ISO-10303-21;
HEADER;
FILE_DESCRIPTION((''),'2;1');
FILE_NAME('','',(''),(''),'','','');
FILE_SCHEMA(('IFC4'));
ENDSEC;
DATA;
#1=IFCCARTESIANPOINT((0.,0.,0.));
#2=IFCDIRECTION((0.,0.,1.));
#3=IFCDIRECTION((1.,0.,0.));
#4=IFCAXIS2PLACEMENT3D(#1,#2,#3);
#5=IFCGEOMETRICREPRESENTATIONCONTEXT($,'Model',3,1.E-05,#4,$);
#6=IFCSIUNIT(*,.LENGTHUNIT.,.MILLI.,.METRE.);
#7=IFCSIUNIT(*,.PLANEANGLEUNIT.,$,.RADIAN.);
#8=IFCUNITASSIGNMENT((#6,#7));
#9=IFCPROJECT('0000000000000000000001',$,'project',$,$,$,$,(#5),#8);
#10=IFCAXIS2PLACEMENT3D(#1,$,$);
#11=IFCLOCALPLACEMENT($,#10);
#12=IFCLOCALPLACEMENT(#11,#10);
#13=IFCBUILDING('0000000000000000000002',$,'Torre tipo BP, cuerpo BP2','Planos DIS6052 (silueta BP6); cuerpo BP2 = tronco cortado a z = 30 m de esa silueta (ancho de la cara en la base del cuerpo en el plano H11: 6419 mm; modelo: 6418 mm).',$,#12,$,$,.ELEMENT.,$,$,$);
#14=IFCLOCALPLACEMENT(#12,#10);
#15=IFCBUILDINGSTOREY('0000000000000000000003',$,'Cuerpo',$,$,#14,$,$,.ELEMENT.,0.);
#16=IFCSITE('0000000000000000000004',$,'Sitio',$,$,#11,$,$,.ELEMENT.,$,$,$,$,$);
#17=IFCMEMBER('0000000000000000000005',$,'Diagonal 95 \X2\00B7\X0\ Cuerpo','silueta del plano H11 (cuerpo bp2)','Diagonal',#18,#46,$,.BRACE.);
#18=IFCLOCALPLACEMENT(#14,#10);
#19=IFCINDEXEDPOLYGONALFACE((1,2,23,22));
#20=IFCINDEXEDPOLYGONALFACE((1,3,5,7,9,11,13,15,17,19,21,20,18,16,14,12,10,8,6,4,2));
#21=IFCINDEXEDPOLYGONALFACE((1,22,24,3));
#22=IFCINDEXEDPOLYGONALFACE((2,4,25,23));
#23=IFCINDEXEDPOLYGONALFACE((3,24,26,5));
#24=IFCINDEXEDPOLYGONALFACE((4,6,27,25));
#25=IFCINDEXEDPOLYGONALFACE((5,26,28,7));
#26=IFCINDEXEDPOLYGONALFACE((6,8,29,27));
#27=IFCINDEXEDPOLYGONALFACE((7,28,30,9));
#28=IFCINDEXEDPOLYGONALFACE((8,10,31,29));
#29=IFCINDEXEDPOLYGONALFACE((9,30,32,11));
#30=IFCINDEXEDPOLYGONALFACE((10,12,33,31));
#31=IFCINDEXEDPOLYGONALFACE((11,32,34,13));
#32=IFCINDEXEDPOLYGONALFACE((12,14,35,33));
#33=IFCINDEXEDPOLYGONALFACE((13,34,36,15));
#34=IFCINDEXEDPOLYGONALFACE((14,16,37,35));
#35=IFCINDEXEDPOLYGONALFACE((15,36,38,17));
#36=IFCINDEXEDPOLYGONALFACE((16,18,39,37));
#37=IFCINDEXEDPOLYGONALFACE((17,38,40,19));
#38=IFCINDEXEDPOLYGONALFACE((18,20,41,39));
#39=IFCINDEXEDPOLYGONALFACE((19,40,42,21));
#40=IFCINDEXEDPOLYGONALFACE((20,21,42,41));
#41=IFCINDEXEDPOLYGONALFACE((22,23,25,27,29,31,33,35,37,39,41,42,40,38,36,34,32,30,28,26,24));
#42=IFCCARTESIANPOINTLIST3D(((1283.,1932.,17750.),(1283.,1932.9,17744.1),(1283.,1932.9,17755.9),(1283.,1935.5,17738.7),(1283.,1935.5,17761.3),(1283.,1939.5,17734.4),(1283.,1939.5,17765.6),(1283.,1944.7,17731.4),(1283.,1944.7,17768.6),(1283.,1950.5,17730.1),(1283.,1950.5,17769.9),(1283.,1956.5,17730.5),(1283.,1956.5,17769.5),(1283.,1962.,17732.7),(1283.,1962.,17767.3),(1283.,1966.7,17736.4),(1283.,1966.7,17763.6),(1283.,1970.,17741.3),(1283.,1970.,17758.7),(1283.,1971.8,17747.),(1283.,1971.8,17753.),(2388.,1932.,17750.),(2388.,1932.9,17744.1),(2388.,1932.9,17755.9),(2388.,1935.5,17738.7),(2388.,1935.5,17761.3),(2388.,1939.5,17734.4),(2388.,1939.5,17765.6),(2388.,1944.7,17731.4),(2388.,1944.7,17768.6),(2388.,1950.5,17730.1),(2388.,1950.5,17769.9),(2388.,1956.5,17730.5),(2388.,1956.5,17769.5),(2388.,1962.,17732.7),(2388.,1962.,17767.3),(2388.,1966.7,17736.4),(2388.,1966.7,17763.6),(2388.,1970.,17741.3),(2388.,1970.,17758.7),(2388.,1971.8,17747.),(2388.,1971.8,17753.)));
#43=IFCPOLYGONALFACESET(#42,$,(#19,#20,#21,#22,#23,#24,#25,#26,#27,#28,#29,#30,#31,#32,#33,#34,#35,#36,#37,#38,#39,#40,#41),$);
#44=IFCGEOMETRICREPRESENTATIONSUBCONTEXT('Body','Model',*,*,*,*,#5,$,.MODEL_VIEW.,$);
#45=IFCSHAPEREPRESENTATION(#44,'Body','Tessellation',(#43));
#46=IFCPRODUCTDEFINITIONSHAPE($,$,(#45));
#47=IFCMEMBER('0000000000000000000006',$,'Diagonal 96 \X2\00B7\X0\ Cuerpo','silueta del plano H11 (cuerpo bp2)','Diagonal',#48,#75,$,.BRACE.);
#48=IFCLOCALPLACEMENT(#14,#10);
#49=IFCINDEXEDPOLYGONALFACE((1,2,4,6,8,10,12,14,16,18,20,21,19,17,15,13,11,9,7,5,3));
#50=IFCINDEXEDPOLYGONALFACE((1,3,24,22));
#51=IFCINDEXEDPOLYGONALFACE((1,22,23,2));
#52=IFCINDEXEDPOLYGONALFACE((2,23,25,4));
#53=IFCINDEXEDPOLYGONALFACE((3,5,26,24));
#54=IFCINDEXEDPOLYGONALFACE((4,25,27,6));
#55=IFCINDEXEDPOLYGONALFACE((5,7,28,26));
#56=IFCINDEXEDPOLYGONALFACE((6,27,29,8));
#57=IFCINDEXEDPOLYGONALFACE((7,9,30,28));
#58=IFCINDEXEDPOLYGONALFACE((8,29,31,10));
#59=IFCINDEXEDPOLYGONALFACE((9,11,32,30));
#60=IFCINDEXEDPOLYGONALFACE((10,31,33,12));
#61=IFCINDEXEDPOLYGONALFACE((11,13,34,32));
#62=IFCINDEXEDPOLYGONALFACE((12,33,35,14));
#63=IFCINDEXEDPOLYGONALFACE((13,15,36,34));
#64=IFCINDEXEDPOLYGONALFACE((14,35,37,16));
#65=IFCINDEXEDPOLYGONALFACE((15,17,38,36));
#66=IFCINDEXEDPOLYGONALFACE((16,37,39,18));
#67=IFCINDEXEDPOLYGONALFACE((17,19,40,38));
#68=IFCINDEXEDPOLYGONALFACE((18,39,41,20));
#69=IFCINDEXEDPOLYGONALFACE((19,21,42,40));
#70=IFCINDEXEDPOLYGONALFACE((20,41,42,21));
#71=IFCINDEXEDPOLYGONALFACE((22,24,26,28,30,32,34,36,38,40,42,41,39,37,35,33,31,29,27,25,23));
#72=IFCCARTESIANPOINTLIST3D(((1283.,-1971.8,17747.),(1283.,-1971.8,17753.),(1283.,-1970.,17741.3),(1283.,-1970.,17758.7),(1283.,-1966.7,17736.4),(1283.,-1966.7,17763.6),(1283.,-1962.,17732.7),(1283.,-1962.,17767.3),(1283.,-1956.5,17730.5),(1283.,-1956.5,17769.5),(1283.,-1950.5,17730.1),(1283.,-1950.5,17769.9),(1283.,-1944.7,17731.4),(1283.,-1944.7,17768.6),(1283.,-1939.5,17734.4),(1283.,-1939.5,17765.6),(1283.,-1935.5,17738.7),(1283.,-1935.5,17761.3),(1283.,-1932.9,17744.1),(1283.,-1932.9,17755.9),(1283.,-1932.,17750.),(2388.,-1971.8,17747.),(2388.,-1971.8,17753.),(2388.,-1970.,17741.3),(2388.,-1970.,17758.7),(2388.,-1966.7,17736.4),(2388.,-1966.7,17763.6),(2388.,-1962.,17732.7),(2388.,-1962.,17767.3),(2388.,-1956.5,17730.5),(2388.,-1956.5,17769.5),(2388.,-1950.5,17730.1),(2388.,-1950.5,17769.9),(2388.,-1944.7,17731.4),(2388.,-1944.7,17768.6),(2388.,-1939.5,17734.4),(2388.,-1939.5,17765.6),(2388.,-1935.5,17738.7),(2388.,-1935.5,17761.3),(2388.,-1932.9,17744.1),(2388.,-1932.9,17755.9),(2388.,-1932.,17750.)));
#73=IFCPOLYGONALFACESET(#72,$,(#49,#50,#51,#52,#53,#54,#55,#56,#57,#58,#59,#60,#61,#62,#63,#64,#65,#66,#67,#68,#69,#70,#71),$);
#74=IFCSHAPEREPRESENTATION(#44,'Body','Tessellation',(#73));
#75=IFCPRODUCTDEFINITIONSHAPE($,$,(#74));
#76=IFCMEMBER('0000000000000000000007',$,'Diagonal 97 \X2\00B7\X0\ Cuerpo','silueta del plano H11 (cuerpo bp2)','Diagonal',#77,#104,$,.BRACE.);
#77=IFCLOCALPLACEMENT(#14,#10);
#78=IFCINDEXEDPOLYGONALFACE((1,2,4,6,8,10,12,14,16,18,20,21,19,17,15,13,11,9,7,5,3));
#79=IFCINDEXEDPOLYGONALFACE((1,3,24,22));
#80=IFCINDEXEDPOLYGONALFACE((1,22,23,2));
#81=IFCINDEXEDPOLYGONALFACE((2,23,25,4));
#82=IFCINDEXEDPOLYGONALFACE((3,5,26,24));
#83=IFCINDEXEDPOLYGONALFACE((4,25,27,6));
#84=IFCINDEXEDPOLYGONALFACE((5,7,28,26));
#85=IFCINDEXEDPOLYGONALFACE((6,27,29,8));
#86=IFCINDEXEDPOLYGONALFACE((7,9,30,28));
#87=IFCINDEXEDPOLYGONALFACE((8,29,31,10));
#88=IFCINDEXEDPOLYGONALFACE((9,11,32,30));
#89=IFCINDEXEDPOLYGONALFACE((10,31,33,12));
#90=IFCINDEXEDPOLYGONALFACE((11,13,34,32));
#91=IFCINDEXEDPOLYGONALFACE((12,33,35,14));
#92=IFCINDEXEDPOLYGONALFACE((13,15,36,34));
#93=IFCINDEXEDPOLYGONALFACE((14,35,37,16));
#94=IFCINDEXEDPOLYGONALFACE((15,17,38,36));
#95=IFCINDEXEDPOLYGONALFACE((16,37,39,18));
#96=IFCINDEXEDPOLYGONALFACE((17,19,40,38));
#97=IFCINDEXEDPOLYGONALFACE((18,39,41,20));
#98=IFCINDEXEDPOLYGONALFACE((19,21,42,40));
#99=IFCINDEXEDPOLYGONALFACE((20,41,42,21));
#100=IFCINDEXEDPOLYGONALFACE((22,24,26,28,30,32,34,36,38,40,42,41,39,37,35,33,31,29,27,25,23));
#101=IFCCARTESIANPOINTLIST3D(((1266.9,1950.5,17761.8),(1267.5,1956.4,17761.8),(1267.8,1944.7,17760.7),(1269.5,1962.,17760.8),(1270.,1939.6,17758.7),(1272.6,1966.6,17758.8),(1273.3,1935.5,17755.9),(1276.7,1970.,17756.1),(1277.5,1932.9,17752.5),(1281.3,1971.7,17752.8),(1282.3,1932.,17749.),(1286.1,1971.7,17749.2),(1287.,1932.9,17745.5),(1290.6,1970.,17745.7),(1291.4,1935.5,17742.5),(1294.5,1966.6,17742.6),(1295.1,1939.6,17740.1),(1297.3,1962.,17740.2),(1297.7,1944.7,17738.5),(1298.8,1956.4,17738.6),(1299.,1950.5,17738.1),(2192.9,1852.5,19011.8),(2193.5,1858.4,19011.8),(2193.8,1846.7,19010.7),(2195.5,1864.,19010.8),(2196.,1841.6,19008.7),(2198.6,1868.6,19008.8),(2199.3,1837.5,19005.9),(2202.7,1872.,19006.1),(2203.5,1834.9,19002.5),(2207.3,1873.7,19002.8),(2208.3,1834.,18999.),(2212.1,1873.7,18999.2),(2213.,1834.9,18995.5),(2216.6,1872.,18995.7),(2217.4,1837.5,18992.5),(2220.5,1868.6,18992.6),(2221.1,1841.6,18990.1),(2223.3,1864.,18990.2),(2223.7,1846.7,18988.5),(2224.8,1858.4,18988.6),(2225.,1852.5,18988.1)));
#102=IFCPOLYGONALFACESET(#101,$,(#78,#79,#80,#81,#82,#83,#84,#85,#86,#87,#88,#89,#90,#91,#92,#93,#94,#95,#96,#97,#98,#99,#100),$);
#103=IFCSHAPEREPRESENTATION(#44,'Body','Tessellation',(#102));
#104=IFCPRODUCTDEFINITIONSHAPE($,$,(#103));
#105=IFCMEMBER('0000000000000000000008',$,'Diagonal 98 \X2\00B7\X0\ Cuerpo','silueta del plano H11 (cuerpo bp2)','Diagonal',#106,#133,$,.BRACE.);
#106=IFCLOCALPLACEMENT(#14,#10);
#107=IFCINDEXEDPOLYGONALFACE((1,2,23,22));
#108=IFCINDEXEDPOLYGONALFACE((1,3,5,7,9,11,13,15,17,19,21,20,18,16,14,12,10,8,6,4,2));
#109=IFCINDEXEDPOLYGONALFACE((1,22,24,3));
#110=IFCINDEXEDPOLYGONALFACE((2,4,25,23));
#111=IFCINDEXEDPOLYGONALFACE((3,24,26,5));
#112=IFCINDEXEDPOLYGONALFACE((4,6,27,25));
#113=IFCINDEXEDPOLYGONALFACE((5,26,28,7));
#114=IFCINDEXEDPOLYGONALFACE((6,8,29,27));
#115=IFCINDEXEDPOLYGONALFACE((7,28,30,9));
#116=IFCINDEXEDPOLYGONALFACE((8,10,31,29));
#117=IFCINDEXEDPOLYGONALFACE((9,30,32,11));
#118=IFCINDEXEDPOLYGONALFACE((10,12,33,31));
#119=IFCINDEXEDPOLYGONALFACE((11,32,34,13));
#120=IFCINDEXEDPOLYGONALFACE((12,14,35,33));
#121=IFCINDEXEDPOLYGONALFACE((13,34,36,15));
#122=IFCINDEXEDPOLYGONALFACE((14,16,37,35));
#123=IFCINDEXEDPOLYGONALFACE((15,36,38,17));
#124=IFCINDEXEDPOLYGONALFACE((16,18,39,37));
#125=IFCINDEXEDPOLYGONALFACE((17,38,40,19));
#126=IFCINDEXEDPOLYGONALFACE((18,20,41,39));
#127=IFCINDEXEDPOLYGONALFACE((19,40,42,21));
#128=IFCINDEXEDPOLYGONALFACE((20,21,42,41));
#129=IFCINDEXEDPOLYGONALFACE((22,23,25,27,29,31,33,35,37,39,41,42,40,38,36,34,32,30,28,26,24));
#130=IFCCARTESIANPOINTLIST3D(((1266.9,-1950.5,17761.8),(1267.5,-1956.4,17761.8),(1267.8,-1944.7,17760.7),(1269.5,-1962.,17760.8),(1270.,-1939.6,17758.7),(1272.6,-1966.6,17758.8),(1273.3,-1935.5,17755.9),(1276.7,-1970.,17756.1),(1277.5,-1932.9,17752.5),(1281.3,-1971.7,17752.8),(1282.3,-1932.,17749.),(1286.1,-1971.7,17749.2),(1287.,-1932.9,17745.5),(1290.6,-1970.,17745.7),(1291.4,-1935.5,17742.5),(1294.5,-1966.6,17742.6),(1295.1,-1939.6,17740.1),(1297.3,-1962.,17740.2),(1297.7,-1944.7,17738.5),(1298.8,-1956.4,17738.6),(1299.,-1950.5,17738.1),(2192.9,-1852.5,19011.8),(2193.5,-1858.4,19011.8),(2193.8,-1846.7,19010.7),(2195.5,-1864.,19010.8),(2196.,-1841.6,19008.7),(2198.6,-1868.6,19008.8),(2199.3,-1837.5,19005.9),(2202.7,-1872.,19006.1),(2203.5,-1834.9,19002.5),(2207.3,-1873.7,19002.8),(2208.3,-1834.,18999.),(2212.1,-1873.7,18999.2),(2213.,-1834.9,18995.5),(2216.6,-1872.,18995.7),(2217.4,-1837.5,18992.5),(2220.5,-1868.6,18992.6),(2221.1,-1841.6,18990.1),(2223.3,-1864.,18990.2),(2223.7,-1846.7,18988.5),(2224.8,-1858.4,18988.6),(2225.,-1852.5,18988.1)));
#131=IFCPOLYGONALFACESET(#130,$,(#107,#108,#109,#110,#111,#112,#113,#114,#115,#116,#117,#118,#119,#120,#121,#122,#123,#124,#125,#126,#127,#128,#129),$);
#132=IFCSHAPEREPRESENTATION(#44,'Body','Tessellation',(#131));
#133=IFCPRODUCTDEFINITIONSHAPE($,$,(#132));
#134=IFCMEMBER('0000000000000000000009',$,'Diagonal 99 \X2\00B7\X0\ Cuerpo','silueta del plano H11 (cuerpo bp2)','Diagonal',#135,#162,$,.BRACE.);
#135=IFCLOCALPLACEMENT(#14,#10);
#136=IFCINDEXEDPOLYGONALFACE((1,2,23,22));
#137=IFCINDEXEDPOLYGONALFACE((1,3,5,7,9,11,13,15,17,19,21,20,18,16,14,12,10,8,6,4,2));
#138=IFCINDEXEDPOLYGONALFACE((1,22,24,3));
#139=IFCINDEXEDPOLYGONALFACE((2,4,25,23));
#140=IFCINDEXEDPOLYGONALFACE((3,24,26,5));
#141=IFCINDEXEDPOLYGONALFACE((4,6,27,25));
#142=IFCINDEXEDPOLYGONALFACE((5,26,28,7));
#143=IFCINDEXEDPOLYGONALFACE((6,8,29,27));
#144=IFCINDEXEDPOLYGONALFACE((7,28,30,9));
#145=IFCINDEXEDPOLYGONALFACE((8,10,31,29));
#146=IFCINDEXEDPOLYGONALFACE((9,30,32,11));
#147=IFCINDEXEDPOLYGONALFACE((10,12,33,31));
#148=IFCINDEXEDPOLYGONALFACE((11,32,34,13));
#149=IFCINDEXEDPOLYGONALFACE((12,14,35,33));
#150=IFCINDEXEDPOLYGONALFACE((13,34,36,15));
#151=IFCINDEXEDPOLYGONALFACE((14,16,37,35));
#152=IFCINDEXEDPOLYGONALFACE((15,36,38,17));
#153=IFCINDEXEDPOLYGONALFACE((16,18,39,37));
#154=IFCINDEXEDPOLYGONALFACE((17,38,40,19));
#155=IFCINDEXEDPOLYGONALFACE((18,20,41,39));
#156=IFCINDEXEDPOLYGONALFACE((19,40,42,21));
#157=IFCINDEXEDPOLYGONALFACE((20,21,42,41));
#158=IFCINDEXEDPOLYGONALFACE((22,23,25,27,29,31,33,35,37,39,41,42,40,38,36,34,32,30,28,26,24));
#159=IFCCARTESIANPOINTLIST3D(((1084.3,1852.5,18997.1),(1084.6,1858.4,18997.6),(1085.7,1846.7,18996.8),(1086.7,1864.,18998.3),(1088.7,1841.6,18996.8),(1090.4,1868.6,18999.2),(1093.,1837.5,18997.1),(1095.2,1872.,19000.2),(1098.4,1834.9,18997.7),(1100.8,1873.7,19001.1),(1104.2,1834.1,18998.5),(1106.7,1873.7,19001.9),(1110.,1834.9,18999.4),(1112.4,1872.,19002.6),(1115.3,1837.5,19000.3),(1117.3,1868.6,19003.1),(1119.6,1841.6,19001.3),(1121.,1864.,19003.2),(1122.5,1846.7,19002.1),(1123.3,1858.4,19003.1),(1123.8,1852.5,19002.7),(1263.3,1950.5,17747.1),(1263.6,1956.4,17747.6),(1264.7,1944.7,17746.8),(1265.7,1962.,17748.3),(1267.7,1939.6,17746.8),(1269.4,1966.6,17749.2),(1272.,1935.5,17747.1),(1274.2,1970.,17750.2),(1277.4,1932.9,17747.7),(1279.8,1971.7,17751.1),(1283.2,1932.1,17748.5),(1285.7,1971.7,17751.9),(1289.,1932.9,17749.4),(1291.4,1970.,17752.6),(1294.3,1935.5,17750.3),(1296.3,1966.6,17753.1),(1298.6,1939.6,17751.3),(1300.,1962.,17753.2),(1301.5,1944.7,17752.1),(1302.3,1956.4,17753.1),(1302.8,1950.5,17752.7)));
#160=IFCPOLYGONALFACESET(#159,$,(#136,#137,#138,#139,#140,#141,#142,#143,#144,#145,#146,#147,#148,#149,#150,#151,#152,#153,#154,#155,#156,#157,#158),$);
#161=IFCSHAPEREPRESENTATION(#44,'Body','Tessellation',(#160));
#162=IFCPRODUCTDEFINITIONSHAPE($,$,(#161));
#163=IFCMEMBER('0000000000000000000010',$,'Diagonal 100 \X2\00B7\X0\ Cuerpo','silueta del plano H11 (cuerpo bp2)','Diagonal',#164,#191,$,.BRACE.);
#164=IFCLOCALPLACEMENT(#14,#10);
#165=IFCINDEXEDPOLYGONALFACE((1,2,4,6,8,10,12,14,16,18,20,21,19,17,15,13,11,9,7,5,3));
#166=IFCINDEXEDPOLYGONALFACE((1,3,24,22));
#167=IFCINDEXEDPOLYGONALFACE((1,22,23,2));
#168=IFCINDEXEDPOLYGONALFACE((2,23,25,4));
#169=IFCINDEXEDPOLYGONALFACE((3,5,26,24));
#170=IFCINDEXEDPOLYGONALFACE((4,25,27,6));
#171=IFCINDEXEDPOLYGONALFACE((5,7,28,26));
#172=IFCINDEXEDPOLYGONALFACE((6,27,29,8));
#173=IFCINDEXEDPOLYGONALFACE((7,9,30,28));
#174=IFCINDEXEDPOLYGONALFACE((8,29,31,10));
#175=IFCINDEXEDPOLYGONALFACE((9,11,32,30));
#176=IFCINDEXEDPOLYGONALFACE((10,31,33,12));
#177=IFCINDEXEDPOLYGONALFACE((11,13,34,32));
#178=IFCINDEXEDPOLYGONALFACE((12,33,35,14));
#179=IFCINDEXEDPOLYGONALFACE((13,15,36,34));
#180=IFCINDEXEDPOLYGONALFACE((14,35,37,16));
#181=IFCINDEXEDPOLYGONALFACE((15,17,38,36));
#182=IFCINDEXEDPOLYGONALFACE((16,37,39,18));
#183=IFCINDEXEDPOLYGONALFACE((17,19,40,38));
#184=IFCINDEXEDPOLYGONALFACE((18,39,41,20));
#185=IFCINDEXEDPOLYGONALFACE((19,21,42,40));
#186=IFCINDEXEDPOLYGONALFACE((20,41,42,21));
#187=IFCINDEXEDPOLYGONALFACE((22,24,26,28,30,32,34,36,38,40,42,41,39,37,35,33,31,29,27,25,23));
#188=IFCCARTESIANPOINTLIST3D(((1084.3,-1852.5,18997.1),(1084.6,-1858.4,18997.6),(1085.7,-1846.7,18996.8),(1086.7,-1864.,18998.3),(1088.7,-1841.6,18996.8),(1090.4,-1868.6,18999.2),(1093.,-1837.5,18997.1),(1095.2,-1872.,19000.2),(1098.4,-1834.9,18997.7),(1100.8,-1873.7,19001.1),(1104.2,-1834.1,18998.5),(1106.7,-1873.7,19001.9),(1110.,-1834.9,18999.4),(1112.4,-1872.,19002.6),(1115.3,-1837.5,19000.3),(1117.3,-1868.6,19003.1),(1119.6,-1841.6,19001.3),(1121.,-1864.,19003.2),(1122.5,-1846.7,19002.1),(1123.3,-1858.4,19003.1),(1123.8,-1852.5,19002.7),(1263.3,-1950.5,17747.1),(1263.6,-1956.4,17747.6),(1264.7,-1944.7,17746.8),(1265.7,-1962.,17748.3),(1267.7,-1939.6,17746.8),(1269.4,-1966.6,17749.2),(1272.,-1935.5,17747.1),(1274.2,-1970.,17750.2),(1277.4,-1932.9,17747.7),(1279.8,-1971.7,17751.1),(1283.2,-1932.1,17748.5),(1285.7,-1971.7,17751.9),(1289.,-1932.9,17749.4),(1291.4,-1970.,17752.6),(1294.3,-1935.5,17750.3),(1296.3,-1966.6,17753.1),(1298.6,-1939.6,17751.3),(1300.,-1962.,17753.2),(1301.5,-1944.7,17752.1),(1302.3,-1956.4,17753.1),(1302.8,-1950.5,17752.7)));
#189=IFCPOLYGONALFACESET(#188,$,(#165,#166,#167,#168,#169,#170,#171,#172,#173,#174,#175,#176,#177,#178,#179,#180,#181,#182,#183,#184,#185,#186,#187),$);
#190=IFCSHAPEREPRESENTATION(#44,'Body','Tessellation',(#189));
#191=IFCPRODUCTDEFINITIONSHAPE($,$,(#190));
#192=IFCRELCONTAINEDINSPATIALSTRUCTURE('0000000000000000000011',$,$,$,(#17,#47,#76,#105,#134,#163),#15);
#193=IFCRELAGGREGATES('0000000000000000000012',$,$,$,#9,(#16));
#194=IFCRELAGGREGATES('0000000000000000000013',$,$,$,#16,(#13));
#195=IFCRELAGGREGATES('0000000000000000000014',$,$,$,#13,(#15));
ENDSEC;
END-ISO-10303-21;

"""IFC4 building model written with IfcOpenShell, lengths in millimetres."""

from ifc_helpers import new_model, si_unit, frame, origin, origin_with_axes, place, context, subcontext, project, spatial, circle, extrude, element, save


model = new_model("IFC4")

# Units and contexts
model_context = context("Model", 3, precision=1e-05, world=origin_with_axes())
body_context = subcontext(model_context, "Body", "Model", "MODEL_VIEW")
ifc_project = project(units=[si_unit("LENGTHUNIT", "METRE", prefix="MILLI"), si_unit("PLANEANGLEUNIT", "RADIAN")], contexts=[model_context])

# Site, building, storey
site_placement = place(None, origin())
site = spatial("IfcSite", under=ifc_project, at=site_placement, Name="Sitio", CompositionType="ELEMENT")
building_placement = place(site_placement, origin())
building = spatial("IfcBuilding", under=site, at=building_placement, Name="Torre tipo BP, cuerpo BP2", Description="Planos DIS6052 (silueta BP6); cuerpo BP2 = tronco cortado a z = 30 m de esa silueta (ancho de la cara en la base del cuerpo en el plano H11: 6419 mm; modelo: 6418 mm).", CompositionType="ELEMENT")
storey_placement = place(building_placement, origin())
storey = spatial("IfcBuildingStorey", under=building, at=storey_placement, Name="Cuerpo", CompositionType="ELEMENT", Elevation=0.0)

# Members
for number, where, z_axis, x_axis, name in (
    (1, (2388.0, 1952.0, 17750.0), (-1.0, 0.0, 0.0), (0.0, -1.0, 0.0), "Diagonal 95 · Cuerpo"),
    (2, (2388.0, -1952.0, 17750.0), (-1.0, 0.0, 0.0), (0.0, 1.0, 0.0), "Diagonal 96 · Cuerpo"),
):
    element("IfcMember", number, at=place(storey_placement, frame(where, z_axis=z_axis, x_axis=x_axis)), inside=storey, Name=name, Description="silueta del plano H11 (cuerpo bp2)", ObjectType="Diagonal", PredefinedType="BRACE", context=body_context, shape_type="SweptSolid", body=[
        extrude(circle(Radius=20.0), None, (0.0, 0.0, 1.0), 1105.0),
    ])
for number, where, z_axis, x_axis, name in (
    (3, (2209.0, 1854.0, 19000.0), (-0.594081, 0.062872, -0.801945), (-0.037425, -0.998022, -0.05052), "Diagonal 97 · Cuerpo"),
    (4, (2209.0, -1854.0, 19000.0), (-0.594081, -0.062872, -0.801945), (-0.037425, 0.998022, -0.05052), "Diagonal 98 · Cuerpo"),
):
    element("IfcMember", number, at=place(storey_placement, frame(where, z_axis=z_axis, x_axis=x_axis)), inside=storey, Name=name, Description="silueta del plano H11 (cuerpo bp2)", ObjectType="Diagonal", PredefinedType="BRACE", context=body_context, shape_type="SweptSolid", body=[
        extrude(circle(Radius=20.0), None, (0.0, 0.0, 1.0), 1558.7),
    ])
for number, where, z_axis, x_axis, name in (
    (5, (1283.0, 1952.0, 17750.0), (-0.141329, -0.077376, 0.986934), (0.010968, -0.997002, -0.076594), "Diagonal 99 · Cuerpo"),
    (6, (1283.0, -1952.0, 17750.0), (-0.141329, 0.077376, 0.986934), (0.010968, 0.997002, -0.076594), "Diagonal 100 · Cuerpo"),
):
    element("IfcMember", number, at=place(storey_placement, frame(where, z_axis=z_axis, x_axis=x_axis)), inside=storey, Name=name, Description="silueta del plano H11 (cuerpo bp2)", ObjectType="Diagonal", PredefinedType="BRACE", context=body_context, shape_type="SweptSolid", body=[
        extrude(circle(Radius=20.0), None, (0.0, 0.0, 1.0), 1266.5),
    ])

save(model, "model.ifc")
